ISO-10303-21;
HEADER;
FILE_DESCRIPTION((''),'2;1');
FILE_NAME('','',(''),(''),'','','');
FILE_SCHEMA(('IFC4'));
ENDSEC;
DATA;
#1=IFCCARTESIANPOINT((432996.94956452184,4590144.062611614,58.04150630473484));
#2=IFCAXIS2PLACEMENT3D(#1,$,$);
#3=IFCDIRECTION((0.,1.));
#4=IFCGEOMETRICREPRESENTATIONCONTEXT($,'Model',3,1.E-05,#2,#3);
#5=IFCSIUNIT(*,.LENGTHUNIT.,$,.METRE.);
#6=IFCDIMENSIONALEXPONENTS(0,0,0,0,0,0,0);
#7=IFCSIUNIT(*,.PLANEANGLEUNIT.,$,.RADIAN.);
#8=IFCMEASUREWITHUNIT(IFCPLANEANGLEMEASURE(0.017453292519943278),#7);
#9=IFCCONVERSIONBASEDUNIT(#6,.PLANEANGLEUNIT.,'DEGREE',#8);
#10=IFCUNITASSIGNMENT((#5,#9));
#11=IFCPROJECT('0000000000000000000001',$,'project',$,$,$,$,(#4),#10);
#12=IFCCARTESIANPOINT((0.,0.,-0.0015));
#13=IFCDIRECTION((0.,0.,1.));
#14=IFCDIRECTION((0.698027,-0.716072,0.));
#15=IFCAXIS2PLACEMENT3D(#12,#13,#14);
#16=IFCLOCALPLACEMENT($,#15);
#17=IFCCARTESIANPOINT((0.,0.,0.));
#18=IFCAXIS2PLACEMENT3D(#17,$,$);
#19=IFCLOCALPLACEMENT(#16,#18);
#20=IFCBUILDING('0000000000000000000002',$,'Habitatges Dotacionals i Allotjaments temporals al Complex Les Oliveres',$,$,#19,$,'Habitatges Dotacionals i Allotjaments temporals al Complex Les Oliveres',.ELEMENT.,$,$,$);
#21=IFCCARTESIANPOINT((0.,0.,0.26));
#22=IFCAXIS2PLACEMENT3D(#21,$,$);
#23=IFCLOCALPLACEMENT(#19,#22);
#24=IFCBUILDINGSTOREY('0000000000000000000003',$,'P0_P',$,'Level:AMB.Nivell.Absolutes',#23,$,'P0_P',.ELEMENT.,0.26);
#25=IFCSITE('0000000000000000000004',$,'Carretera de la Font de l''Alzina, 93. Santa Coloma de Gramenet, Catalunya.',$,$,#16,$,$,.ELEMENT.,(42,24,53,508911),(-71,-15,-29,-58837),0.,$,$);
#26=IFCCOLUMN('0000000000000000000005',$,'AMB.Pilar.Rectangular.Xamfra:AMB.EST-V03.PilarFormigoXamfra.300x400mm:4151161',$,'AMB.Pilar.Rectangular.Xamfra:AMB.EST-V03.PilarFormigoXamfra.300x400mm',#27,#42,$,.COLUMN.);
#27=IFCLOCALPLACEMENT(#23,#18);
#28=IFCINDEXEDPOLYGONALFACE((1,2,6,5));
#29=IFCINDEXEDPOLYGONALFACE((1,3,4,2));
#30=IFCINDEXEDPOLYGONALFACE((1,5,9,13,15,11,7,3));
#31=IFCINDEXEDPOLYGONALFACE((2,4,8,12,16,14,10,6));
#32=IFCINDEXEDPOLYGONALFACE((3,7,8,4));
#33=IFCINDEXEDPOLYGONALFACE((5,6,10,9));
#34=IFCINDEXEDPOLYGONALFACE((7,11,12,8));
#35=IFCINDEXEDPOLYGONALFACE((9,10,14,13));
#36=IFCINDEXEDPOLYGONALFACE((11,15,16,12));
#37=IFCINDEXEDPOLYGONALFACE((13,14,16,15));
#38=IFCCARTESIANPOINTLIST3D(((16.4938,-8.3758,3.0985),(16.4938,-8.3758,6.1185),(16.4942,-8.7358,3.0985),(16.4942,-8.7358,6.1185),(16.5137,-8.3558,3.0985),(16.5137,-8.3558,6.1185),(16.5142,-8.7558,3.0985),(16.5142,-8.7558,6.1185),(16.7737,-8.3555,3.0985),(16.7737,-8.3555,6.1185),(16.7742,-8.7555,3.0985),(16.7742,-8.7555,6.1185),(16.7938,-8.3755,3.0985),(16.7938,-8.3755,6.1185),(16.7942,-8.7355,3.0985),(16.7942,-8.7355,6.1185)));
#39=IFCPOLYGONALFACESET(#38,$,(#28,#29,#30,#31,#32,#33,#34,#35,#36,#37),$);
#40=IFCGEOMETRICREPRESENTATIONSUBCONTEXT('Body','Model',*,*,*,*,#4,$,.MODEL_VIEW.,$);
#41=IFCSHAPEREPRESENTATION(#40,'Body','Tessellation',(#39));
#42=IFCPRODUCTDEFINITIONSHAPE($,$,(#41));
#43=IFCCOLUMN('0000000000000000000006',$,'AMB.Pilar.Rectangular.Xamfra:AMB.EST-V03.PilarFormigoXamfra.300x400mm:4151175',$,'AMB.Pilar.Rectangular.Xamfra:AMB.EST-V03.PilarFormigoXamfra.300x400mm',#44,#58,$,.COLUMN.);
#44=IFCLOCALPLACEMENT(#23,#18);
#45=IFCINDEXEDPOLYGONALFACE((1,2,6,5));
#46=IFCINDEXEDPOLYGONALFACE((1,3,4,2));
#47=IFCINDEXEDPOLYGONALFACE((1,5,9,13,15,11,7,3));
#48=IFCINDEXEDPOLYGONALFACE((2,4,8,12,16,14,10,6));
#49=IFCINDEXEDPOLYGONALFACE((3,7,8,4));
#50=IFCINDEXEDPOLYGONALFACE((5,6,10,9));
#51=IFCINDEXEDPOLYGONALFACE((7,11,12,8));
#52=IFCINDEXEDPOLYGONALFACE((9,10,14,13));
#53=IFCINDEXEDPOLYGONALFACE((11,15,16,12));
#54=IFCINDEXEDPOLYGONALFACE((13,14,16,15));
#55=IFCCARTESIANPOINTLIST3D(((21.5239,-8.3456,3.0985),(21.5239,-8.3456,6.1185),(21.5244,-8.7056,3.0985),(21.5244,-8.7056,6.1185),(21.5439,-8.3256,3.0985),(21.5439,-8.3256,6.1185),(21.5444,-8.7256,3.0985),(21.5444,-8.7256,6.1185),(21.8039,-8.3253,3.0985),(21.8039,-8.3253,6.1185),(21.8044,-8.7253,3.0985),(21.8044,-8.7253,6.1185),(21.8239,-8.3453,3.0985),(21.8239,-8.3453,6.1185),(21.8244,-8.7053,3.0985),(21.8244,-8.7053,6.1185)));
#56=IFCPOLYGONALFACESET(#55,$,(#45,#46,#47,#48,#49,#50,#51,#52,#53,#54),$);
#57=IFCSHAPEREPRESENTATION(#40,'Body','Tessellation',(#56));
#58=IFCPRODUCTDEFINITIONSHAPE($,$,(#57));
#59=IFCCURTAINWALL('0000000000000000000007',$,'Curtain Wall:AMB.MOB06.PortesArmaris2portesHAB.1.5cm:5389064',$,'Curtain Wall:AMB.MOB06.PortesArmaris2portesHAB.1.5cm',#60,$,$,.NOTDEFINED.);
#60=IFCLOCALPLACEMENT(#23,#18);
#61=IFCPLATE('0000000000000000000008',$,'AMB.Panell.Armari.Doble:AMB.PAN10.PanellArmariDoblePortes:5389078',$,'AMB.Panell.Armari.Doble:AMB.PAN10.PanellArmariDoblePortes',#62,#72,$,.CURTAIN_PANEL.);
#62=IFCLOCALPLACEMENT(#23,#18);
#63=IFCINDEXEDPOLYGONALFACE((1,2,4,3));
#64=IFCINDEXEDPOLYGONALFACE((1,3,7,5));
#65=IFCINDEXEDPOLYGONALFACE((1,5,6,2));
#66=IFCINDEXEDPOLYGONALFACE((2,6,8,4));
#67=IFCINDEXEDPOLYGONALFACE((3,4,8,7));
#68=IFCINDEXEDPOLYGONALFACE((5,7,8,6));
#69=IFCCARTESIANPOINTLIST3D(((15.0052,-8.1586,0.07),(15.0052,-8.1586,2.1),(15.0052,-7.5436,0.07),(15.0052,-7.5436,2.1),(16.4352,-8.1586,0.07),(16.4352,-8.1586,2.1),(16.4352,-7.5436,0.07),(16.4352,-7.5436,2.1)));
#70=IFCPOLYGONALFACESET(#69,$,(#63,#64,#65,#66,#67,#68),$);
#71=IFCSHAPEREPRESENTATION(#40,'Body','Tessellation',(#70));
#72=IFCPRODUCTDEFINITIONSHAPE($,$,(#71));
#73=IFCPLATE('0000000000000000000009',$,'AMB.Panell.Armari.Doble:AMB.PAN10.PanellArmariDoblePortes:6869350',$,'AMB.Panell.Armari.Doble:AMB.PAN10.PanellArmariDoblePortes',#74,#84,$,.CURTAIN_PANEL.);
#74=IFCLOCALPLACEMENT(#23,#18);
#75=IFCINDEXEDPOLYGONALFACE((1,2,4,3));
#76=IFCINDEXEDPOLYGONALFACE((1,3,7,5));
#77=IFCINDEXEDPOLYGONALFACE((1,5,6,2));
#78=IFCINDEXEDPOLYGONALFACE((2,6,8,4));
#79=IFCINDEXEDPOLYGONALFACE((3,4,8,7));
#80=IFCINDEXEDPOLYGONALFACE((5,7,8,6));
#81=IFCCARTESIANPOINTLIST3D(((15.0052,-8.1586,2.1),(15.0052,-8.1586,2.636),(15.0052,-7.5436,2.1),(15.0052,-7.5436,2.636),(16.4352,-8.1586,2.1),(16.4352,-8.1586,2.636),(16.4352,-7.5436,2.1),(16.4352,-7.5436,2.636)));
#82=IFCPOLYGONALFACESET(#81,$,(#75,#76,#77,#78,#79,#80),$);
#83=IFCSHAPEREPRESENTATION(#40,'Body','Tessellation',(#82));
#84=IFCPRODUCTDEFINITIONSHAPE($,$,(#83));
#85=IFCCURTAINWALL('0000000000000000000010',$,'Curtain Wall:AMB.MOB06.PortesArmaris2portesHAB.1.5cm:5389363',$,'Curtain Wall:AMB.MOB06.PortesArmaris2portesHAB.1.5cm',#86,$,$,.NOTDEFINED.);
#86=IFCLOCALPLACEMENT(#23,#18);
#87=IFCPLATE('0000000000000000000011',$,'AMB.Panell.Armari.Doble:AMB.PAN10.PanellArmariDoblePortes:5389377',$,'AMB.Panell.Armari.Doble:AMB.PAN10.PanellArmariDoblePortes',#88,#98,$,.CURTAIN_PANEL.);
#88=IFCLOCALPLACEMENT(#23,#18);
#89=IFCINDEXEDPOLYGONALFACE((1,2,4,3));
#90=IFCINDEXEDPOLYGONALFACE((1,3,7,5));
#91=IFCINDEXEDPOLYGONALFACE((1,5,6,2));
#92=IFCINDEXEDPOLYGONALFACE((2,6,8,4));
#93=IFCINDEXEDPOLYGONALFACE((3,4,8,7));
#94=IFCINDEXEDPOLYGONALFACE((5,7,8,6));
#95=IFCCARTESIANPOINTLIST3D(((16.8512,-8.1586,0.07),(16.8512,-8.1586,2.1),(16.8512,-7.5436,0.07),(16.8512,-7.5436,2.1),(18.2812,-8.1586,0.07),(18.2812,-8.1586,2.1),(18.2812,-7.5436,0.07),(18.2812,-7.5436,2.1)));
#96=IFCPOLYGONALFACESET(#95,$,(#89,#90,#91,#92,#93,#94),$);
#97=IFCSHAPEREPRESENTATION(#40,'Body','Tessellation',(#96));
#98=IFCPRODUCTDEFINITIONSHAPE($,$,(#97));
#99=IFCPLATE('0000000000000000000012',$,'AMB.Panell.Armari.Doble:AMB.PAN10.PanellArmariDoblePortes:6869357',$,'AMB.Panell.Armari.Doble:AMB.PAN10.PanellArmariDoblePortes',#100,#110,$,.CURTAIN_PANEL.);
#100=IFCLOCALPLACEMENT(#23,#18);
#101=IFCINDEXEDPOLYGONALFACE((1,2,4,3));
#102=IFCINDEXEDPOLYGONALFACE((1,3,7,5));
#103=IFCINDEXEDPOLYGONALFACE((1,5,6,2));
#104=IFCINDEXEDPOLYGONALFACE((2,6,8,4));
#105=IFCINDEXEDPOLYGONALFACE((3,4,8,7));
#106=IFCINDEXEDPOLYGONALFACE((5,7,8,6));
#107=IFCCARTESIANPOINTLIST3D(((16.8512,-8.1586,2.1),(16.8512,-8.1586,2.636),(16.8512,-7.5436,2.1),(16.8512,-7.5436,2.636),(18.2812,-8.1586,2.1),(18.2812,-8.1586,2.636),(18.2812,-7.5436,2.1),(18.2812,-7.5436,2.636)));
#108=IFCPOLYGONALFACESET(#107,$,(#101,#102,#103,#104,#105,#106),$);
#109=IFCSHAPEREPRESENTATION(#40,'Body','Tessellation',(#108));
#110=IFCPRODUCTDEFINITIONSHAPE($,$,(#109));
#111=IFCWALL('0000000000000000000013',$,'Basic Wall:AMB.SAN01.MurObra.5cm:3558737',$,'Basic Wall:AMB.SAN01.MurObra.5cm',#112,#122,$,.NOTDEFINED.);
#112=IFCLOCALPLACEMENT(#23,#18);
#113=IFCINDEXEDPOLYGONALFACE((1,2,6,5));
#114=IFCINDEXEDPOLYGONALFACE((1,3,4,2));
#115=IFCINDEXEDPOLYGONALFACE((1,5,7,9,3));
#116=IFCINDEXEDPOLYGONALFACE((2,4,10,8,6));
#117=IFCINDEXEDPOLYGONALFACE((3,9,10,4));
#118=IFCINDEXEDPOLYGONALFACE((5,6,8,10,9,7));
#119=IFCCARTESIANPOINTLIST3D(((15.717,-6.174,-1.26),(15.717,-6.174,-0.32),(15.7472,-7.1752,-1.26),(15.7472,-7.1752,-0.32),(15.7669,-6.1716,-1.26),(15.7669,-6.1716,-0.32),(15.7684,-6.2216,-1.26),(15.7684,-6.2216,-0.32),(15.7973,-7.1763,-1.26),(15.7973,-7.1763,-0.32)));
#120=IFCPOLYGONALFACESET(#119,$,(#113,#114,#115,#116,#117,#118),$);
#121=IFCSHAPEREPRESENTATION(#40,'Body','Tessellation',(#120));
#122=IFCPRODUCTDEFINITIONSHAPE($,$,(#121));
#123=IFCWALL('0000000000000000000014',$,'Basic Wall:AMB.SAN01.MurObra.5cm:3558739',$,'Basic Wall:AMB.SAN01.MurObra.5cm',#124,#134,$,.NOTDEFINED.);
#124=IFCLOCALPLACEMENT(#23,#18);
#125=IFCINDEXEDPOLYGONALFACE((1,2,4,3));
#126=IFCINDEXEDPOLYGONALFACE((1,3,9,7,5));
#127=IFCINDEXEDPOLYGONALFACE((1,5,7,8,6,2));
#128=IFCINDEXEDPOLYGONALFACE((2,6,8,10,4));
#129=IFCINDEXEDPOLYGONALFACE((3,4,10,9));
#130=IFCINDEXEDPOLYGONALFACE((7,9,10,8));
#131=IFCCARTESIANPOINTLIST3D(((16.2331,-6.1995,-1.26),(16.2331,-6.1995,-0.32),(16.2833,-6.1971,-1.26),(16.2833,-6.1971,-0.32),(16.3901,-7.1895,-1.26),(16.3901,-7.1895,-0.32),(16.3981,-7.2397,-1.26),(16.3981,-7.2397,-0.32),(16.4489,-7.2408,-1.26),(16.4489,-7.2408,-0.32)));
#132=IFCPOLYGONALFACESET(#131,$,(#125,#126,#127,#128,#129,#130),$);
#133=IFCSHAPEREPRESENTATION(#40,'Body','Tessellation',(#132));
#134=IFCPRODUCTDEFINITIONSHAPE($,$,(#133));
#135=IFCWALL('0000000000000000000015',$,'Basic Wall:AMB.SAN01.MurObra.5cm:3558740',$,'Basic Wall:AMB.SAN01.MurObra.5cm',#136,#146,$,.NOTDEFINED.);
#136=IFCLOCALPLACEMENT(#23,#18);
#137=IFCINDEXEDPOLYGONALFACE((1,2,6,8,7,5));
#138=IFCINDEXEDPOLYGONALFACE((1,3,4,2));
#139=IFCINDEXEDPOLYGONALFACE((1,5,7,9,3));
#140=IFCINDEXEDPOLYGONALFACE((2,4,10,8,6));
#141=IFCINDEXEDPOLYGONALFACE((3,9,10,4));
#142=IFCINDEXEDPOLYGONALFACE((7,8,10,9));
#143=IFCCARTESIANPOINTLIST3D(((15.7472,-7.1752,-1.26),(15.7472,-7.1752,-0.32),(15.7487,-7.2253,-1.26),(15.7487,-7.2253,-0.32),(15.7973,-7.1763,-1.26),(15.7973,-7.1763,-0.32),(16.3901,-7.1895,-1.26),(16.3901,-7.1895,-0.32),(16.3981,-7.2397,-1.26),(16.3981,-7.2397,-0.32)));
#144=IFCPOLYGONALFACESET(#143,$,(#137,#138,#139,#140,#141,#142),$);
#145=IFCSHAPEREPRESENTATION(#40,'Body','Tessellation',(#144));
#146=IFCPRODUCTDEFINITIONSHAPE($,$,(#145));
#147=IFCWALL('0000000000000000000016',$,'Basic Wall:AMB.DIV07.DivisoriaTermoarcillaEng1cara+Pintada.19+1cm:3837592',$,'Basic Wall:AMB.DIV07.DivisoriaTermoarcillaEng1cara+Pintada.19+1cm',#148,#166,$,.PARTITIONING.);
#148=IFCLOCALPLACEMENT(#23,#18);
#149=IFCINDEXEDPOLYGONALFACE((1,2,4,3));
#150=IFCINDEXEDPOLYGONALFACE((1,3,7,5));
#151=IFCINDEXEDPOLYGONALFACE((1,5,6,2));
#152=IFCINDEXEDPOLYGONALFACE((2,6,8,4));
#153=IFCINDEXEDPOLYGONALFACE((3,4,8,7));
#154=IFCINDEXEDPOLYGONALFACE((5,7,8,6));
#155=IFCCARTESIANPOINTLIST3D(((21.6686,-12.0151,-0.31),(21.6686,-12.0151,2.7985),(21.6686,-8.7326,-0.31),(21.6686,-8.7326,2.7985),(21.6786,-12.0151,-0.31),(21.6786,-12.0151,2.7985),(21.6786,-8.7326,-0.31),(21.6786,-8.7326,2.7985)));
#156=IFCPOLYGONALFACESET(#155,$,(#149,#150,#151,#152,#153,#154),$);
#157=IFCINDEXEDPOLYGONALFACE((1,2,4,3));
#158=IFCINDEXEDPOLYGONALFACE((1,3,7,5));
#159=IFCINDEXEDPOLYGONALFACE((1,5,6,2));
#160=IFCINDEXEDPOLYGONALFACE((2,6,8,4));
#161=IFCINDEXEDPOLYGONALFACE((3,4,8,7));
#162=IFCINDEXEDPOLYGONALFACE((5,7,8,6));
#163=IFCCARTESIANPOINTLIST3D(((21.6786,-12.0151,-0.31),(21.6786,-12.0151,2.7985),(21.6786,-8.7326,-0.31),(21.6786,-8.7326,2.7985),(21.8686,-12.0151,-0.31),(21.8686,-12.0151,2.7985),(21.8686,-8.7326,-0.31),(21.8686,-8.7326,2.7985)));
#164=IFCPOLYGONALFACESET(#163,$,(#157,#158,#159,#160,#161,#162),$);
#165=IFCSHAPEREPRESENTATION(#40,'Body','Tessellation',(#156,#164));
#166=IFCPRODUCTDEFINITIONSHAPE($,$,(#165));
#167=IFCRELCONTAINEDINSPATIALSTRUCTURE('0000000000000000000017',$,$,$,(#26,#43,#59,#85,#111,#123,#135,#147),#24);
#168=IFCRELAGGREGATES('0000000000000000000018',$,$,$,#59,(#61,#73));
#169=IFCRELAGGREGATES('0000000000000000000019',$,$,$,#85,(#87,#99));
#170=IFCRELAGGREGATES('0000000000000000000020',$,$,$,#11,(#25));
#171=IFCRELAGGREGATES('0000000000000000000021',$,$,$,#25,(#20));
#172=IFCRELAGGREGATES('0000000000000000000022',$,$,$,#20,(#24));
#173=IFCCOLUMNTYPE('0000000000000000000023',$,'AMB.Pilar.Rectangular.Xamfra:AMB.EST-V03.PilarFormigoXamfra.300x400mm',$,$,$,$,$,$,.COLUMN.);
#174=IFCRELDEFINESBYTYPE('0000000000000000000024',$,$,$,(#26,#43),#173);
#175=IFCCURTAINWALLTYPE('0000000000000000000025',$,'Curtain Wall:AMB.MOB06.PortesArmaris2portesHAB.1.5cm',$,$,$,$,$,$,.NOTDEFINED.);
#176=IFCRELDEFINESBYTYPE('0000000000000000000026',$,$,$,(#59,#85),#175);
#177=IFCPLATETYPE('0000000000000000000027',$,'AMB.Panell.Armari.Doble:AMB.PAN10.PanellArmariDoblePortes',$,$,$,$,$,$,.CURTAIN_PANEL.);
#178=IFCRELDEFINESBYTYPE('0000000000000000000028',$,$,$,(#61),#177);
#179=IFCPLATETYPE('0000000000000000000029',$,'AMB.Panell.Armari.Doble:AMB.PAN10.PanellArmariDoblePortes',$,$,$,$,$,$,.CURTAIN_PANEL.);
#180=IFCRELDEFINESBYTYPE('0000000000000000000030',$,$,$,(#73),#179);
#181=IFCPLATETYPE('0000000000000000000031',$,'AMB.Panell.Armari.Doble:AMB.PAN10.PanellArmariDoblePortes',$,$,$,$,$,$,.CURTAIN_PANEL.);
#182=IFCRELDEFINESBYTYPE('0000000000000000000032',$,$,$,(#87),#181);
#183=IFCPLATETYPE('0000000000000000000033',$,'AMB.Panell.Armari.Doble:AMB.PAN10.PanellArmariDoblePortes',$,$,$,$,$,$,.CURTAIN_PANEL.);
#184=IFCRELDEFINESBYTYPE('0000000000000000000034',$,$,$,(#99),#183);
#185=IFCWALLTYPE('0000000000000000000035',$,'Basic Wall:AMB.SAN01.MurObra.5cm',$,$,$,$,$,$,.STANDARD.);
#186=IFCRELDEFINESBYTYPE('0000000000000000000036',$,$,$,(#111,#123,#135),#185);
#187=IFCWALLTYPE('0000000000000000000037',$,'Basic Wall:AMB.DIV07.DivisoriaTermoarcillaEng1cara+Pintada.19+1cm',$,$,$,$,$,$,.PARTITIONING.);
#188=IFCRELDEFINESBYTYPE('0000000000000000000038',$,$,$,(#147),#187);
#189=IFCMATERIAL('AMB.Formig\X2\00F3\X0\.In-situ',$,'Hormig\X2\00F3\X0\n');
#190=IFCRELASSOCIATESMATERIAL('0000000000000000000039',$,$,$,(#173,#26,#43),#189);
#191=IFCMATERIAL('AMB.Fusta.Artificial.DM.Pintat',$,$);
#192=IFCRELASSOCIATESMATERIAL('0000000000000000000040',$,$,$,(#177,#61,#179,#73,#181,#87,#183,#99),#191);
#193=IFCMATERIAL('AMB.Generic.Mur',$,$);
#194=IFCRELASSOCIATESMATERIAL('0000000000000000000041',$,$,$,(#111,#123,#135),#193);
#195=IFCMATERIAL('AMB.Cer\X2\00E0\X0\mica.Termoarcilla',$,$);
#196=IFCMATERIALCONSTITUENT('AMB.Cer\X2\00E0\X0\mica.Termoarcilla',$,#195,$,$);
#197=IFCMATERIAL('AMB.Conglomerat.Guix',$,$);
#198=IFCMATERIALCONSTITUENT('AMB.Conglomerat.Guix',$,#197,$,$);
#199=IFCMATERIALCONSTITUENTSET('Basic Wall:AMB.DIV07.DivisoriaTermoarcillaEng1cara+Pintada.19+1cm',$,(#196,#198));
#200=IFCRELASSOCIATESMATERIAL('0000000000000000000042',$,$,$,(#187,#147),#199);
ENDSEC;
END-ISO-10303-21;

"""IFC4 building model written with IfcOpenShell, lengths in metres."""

from ifc_helpers import new_model, entity, si_unit, converted_unit, direction, frame, origin, place, context, subcontext, project, spatial, indexed_curve, outline, extrude, source, transform, mapped, material, constituent, constituent_set, type_object, type_shapes, element, aggregate, save


model = new_model("IFC4")

# Units and contexts
model_context = context("Model", 3, precision=1e-05, world=frame((432996.94956452184, 4590144.062611614, 58.04150630473484)), true_north=direction((0.0, 1.0)))
body_context = subcontext(model_context, "Body", "Model", "MODEL_VIEW")
ifc_project = project(units=[si_unit("LENGTHUNIT", "METRE"), converted_unit("PLANEANGLEUNIT", "DEGREE", entity("IfcPlaneAngleMeasure", 0.017453292519943278), si_unit("PLANEANGLEUNIT", "RADIAN"), dimensions=[0, 0, 0, 0, 0, 0, 0])], contexts=[model_context])

# Site, building, storey
site_placement = place(None, frame((0.0, 0.0, -0.0015), z_axis=(0.0, 0.0, 1.0), x_axis=(0.698027, -0.716072, 0.0)))
site = spatial("IfcSite", under=ifc_project, at=site_placement, Name="Carretera de la Font de l'Alzina, 93. Santa Coloma de Gramenet, Catalunya.", CompositionType="ELEMENT", RefLatitude=(42, 24, 53, 508911), RefLongitude=(-71, -15, -29, -58837), RefElevation=0.0)
building_placement = place(site_placement, origin())
building = spatial("IfcBuilding", under=site, at=building_placement, Name="Habitatges Dotacionals i Allotjaments temporals al Complex Les Oliveres", LongName="Habitatges Dotacionals i Allotjaments temporals al Complex Les Oliveres", CompositionType="ELEMENT")
storey_placement = place(building_placement, frame((0.0, 0.0, 0.26)))
storey = spatial("IfcBuildingStorey", under=building, at=storey_placement, Name="P0_P", ObjectType="Level:AMB.Nivell.Absolutes", LongName="P0_P", CompositionType="ELEMENT", Elevation=0.26)

# Columns
ifc_material_1 = material(Name="AMB.Formigó.In-situ", Category="Hormigón")
column_type = type_object("IfcColumnType", Name="AMB.Pilar.Rectangular.Xamfra:AMB.EST-V03.PilarFormigoXamfra.300x400mm", PredefinedType="COLUMN", material=ifc_material_1)
shared_shape_1 = source(origin(), body_context, "Body", "SweptSolid", [
    extrude(outline(indexed_curve([(-0.13, -0.2), (0.13, -0.2), (0.15, -0.18), (0.15, 0.18), (0.13, 0.2), (-0.13, 0.2), (-0.15, 0.18), (-0.15, -0.18), (-0.13, -0.2)], self_intersect=False)), frame((0.0, 0.0, 3.3585), z_axis=(0.0, 0.0, 1.0), x_axis=(-1.0, 0.0, 0.0)), (0.0, 0.0, 1.0), 3.02),
])
type_shapes(column_type, [shared_shape_1])
for number, where, z_axis, x_axis, name in (
    (1, (16.644, -8.5556, -0.26), (0.0, 0.0, 1.0), (0.999999, 0.001194, 0.0), "AMB.Pilar.Rectangular.Xamfra:AMB.EST-V03.PilarFormigoXamfra.300x400mm:4151161"),
    (2, (21.6741, -8.5254, -0.26), (0.0, 0.0, 1.0), (0.999999, 0.001194, 0.0), "AMB.Pilar.Rectangular.Xamfra:AMB.EST-V03.PilarFormigoXamfra.300x400mm:4151175"),
):
    element("IfcColumn", number, at=place(storey_placement, frame(where, z_axis=z_axis, x_axis=x_axis)), inside=storey, type_object=column_type, material=ifc_material_1, Name=name, ObjectType="AMB.Pilar.Rectangular.Xamfra:AMB.EST-V03.PilarFormigoXamfra.300x400mm", PredefinedType="COLUMN", context=body_context, shape_type="MappedRepresentation", body=[
        mapped(shared_shape_1, transform((0.0, 0.0, 0.0), scale=1.0)),
    ])

# Curtain walls, plates
curtain_wall_type = type_object("IfcCurtainWallType", Name="Curtain Wall:AMB.MOB06.PortesArmaris2portesHAB.1.5cm", PredefinedType="NOTDEFINED")
curtain_wall_1_placement = place(storey_placement, frame((0.0, 0.0, -0.26)))
curtain_wall_1 = element("IfcCurtainWall", 3, at=curtain_wall_1_placement, inside=storey, type_object=curtain_wall_type, Name="Curtain Wall:AMB.MOB06.PortesArmaris2portesHAB.1.5cm:5389064", ObjectType="Curtain Wall:AMB.MOB06.PortesArmaris2portesHAB.1.5cm", PredefinedType="NOTDEFINED")
ifc_material_2 = material(Name="AMB.Fusta.Artificial.DM.Pintat")
plate_type_1 = type_object("IfcPlateType", Name="AMB.Panell.Armari.Doble:AMB.PAN10.PanellArmariDoblePortes", PredefinedType="CURTAIN_PANEL", material=ifc_material_2)
shared_shape_2 = source(origin(), body_context, "Body", "SweptSolid", [
    extrude(outline(indexed_curve([(-0.715, -0.3075), (0.715, -0.3075), (0.715, 0.3075), (-0.715, 0.3075), (-0.715, -0.3075)], self_intersect=False)), frame((0.0, -0.3075, 0.0), z_axis=(0.0, 0.0, 1.0), x_axis=(-1.0, 0.0, 0.0)), (0.0, 0.0, 1.0), 2.03),
])
type_shapes(plate_type_1, [shared_shape_2])
plate_1_placement = place(curtain_wall_1_placement, frame((15.7202, -8.1586, 0.33), z_axis=(0.0, 0.0, 1.0), x_axis=(-1.0, 0.0, 0.0)))
plate_1 = element("IfcPlate", 4, at=plate_1_placement, type_object=plate_type_1, material=ifc_material_2, Name="AMB.Panell.Armari.Doble:AMB.PAN10.PanellArmariDoblePortes:5389078", ObjectType="AMB.Panell.Armari.Doble:AMB.PAN10.PanellArmariDoblePortes", PredefinedType="CURTAIN_PANEL", context=body_context, shape_type="MappedRepresentation", body=[
    mapped(shared_shape_2, transform((0.0, 0.0, 0.0), scale=1.0)),
])
plate_type_2 = type_object("IfcPlateType", Name="AMB.Panell.Armari.Doble:AMB.PAN10.PanellArmariDoblePortes", PredefinedType="CURTAIN_PANEL", material=ifc_material_2)
shared_shape_3 = source(origin(), body_context, "Body", "SweptSolid", [
    extrude(outline(indexed_curve([(-0.715, -0.3075), (0.715, -0.3075), (0.715, 0.3075), (-0.715, 0.3075), (-0.715, -0.3075)], self_intersect=False)), frame((0.0, -0.3075, 0.0), z_axis=(0.0, 0.0, 1.0), x_axis=(-1.0, 0.0, 0.0)), (0.0, 0.0, 1.0), 0.536),
])
type_shapes(plate_type_2, [shared_shape_3])
plate_2_placement = place(curtain_wall_1_placement, frame((15.7202, -8.1586, 2.36), z_axis=(0.0, 0.0, 1.0), x_axis=(-1.0, 0.0, 0.0)))
plate_2 = element("IfcPlate", 5, at=plate_2_placement, type_object=plate_type_2, material=ifc_material_2, Name="AMB.Panell.Armari.Doble:AMB.PAN10.PanellArmariDoblePortes:6869350", ObjectType="AMB.Panell.Armari.Doble:AMB.PAN10.PanellArmariDoblePortes", PredefinedType="CURTAIN_PANEL", context=body_context, shape_type="MappedRepresentation", body=[
    mapped(shared_shape_3, transform((0.0, 0.0, 0.0), scale=1.0)),
])
curtain_wall_2_placement = place(storey_placement, frame((0.0, 0.0, -0.26)))
curtain_wall_2 = element("IfcCurtainWall", 6, at=curtain_wall_2_placement, inside=storey, type_object=curtain_wall_type, Name="Curtain Wall:AMB.MOB06.PortesArmaris2portesHAB.1.5cm:5389363", ObjectType="Curtain Wall:AMB.MOB06.PortesArmaris2portesHAB.1.5cm", PredefinedType="NOTDEFINED")
plate_type_3 = type_object("IfcPlateType", Name="AMB.Panell.Armari.Doble:AMB.PAN10.PanellArmariDoblePortes", PredefinedType="CURTAIN_PANEL", material=ifc_material_2)
shared_shape_4 = source(origin(), body_context, "Body", "SweptSolid", [
    extrude(outline(indexed_curve([(-0.3075, -0.715), (0.3075, -0.715), (0.3075, 0.715), (-0.3075, 0.715), (-0.3075, -0.715)], self_intersect=False)), frame((0.0, 0.3075, 0.0), z_axis=(0.0, 0.0, 1.0), x_axis=(0.0, 1.0, 0.0)), (0.0, 0.0, 1.0), 2.03),
])
type_shapes(plate_type_3, [shared_shape_4])
plate_3_placement = place(curtain_wall_2_placement, frame((17.5662, -8.1586, 0.33)))
plate_3 = element("IfcPlate", 7, at=plate_3_placement, type_object=plate_type_3, material=ifc_material_2, Name="AMB.Panell.Armari.Doble:AMB.PAN10.PanellArmariDoblePortes:5389377", ObjectType="AMB.Panell.Armari.Doble:AMB.PAN10.PanellArmariDoblePortes", PredefinedType="CURTAIN_PANEL", context=body_context, shape_type="MappedRepresentation", body=[
    mapped(shared_shape_4, transform((0.0, 0.0, 0.0), scale=1.0)),
])
plate_type_4 = type_object("IfcPlateType", Name="AMB.Panell.Armari.Doble:AMB.PAN10.PanellArmariDoblePortes", PredefinedType="CURTAIN_PANEL", material=ifc_material_2)
shared_shape_5 = source(origin(), body_context, "Body", "SweptSolid", [
    extrude(outline(indexed_curve([(-0.3075, -0.715), (0.3075, -0.715), (0.3075, 0.715), (-0.3075, 0.715), (-0.3075, -0.715)], self_intersect=False)), frame((0.0, 0.3075, 0.0), z_axis=(0.0, 0.0, 1.0), x_axis=(0.0, 1.0, 0.0)), (0.0, 0.0, 1.0), 0.536),
])
type_shapes(plate_type_4, [shared_shape_5])
plate_4_placement = place(curtain_wall_2_placement, frame((17.5662, -8.1586, 2.36)))
plate_4 = element("IfcPlate", 8, at=plate_4_placement, type_object=plate_type_4, material=ifc_material_2, Name="AMB.Panell.Armari.Doble:AMB.PAN10.PanellArmariDoblePortes:6869357", ObjectType="AMB.Panell.Armari.Doble:AMB.PAN10.PanellArmariDoblePortes", PredefinedType="CURTAIN_PANEL", context=body_context, shape_type="MappedRepresentation", body=[
    mapped(shared_shape_5, transform((0.0, 0.0, 0.0), scale=1.0)),
])

# Walls
ifc_material_3 = material(Name="AMB.Generic.Mur")
wall_type_1 = type_object("IfcWallType", Name="Basic Wall:AMB.SAN01.MurObra.5cm", PredefinedType="STANDARD")
wall_1_placement = place(storey_placement, frame((15.7723, -7.1771, -1.26), z_axis=(0.0, 0.0, 1.0), x_axis=(-0.030209, 0.999544, 0.0)))
element("IfcWall", 9, at=wall_1_placement, inside=storey, type_object=wall_type_1, material=ifc_material_3, Name="Basic Wall:AMB.SAN01.MurObra.5cm:3558737", ObjectType="Basic Wall:AMB.SAN01.MurObra.5cm", PredefinedType="NOTDEFINED", context=body_context, shape_type="SweptSolid", body=[
    extrude(outline(indexed_curve([(1.0052, -0.025), (1.0043, 0.025), (0.0026, 0.025), (0.0, -0.025), (0.9551, -0.025), (1.0052, -0.025)], self_intersect=False)), origin(), (0.0, 0.0, 1.0), 0.94),
])
wall_2_placement = place(storey_placement, frame((16.2578, -6.1955, -1.26), z_axis=(0.0, 0.0, 1.0), x_axis=(0.156661, -0.987652, 0.0)))
element("IfcWall", 10, at=wall_2_placement, inside=storey, type_object=wall_type_1, material=ifc_material_3, Name="Basic Wall:AMB.SAN01.MurObra.5cm:3558739", ObjectType="Basic Wall:AMB.SAN01.MurObra.5cm", PredefinedType="NOTDEFINED", context=body_context, shape_type="SweptSolid", body=[
    extrude(outline(indexed_curve([(1.0532, -0.025), (1.0623, 0.025), (0.0055, 0.025), (0.0, -0.025), (1.0024, -0.025), (1.0532, -0.025)], self_intersect=False)), origin(), (0.0, 0.0, 1.0), 0.94),
])
wall_3_placement = place(storey_placement, frame((16.3986, -7.2147, -1.26), z_axis=(0.0, 0.0, 1.0), x_axis=(-0.999755, 0.022145, 0.0)))
element("IfcWall", 11, at=wall_3_placement, inside=storey, type_object=wall_type_1, material=ifc_material_3, Name="Basic Wall:AMB.SAN01.MurObra.5cm:3558740", ObjectType="Basic Wall:AMB.SAN01.MurObra.5cm", PredefinedType="NOTDEFINED", context=body_context, shape_type="SweptSolid", body=[
    extrude(outline(indexed_curve([(0.6521, -0.025), (0.6495, 0.025), (0.0, 0.025), (0.0091, -0.025), (0.6021, -0.025), (0.6521, -0.025)], self_intersect=False)), origin(), (0.0, 0.0, 1.0), 0.94),
])
ifc_material_4 = material(Name="AMB.Ceràmica.Termoarcilla")
ifc_constituent_1 = constituent(ifc_material_4, Name="AMB.Ceràmica.Termoarcilla")
ifc_material_5 = material(Name="AMB.Conglomerat.Guix")
ifc_constituent_2 = constituent(ifc_material_5, Name="AMB.Conglomerat.Guix")
ifc_constituent_set_1 = constituent_set(constituents=[ifc_constituent_1, ifc_constituent_2], Name="Basic Wall:AMB.DIV07.DivisoriaTermoarcillaEng1cara+Pintada.19+1cm")
wall_type_2 = type_object("IfcWallType", Name="Basic Wall:AMB.DIV07.DivisoriaTermoarcillaEng1cara+Pintada.19+1cm", PredefinedType="PARTITIONING", material=ifc_constituent_set_1)
wall_4_placement = place(storey_placement, frame((21.7686, -8.7326, -0.31), z_axis=(0.0, 0.0, 1.0), x_axis=(0.0, -1.0, 0.0)))
element("IfcWall", 12, at=wall_4_placement, inside=storey, type_object=wall_type_2, material=ifc_constituent_set_1, Name="Basic Wall:AMB.DIV07.DivisoriaTermoarcillaEng1cara+Pintada.19+1cm:3837592", ObjectType="Basic Wall:AMB.DIV07.DivisoriaTermoarcillaEng1cara+Pintada.19+1cm", PredefinedType="PARTITIONING", context=body_context, shape_type="SweptSolid", body=[
    extrude(outline(indexed_curve([(-0.005, -1.6413), (0.005, -1.6413), (0.005, 1.6413), (-0.005, 1.6413), (-0.005, -1.6413)], self_intersect=False)), frame((1.6413, -0.095, 0.0), z_axis=(0.0, 0.0, 1.0), x_axis=(0.0, 1.0, 0.0)), (0.0, 0.0, 1.0), 3.1085),
    extrude(outline(indexed_curve([(-0.095, -1.6413), (0.095, -1.6413), (0.095, 1.6413), (-0.095, 1.6413), (-0.095, -1.6413)], self_intersect=False)), frame((1.6413, 0.005, 0.0), z_axis=(0.0, 0.0, 1.0), x_axis=(0.0, -1.0, 0.0)), (0.0, 0.0, 1.0), 3.1085),
])

aggregate(curtain_wall_1, [plate_1, plate_2])
aggregate(curtain_wall_2, [plate_3, plate_4])

save(model, "model.ifc")
